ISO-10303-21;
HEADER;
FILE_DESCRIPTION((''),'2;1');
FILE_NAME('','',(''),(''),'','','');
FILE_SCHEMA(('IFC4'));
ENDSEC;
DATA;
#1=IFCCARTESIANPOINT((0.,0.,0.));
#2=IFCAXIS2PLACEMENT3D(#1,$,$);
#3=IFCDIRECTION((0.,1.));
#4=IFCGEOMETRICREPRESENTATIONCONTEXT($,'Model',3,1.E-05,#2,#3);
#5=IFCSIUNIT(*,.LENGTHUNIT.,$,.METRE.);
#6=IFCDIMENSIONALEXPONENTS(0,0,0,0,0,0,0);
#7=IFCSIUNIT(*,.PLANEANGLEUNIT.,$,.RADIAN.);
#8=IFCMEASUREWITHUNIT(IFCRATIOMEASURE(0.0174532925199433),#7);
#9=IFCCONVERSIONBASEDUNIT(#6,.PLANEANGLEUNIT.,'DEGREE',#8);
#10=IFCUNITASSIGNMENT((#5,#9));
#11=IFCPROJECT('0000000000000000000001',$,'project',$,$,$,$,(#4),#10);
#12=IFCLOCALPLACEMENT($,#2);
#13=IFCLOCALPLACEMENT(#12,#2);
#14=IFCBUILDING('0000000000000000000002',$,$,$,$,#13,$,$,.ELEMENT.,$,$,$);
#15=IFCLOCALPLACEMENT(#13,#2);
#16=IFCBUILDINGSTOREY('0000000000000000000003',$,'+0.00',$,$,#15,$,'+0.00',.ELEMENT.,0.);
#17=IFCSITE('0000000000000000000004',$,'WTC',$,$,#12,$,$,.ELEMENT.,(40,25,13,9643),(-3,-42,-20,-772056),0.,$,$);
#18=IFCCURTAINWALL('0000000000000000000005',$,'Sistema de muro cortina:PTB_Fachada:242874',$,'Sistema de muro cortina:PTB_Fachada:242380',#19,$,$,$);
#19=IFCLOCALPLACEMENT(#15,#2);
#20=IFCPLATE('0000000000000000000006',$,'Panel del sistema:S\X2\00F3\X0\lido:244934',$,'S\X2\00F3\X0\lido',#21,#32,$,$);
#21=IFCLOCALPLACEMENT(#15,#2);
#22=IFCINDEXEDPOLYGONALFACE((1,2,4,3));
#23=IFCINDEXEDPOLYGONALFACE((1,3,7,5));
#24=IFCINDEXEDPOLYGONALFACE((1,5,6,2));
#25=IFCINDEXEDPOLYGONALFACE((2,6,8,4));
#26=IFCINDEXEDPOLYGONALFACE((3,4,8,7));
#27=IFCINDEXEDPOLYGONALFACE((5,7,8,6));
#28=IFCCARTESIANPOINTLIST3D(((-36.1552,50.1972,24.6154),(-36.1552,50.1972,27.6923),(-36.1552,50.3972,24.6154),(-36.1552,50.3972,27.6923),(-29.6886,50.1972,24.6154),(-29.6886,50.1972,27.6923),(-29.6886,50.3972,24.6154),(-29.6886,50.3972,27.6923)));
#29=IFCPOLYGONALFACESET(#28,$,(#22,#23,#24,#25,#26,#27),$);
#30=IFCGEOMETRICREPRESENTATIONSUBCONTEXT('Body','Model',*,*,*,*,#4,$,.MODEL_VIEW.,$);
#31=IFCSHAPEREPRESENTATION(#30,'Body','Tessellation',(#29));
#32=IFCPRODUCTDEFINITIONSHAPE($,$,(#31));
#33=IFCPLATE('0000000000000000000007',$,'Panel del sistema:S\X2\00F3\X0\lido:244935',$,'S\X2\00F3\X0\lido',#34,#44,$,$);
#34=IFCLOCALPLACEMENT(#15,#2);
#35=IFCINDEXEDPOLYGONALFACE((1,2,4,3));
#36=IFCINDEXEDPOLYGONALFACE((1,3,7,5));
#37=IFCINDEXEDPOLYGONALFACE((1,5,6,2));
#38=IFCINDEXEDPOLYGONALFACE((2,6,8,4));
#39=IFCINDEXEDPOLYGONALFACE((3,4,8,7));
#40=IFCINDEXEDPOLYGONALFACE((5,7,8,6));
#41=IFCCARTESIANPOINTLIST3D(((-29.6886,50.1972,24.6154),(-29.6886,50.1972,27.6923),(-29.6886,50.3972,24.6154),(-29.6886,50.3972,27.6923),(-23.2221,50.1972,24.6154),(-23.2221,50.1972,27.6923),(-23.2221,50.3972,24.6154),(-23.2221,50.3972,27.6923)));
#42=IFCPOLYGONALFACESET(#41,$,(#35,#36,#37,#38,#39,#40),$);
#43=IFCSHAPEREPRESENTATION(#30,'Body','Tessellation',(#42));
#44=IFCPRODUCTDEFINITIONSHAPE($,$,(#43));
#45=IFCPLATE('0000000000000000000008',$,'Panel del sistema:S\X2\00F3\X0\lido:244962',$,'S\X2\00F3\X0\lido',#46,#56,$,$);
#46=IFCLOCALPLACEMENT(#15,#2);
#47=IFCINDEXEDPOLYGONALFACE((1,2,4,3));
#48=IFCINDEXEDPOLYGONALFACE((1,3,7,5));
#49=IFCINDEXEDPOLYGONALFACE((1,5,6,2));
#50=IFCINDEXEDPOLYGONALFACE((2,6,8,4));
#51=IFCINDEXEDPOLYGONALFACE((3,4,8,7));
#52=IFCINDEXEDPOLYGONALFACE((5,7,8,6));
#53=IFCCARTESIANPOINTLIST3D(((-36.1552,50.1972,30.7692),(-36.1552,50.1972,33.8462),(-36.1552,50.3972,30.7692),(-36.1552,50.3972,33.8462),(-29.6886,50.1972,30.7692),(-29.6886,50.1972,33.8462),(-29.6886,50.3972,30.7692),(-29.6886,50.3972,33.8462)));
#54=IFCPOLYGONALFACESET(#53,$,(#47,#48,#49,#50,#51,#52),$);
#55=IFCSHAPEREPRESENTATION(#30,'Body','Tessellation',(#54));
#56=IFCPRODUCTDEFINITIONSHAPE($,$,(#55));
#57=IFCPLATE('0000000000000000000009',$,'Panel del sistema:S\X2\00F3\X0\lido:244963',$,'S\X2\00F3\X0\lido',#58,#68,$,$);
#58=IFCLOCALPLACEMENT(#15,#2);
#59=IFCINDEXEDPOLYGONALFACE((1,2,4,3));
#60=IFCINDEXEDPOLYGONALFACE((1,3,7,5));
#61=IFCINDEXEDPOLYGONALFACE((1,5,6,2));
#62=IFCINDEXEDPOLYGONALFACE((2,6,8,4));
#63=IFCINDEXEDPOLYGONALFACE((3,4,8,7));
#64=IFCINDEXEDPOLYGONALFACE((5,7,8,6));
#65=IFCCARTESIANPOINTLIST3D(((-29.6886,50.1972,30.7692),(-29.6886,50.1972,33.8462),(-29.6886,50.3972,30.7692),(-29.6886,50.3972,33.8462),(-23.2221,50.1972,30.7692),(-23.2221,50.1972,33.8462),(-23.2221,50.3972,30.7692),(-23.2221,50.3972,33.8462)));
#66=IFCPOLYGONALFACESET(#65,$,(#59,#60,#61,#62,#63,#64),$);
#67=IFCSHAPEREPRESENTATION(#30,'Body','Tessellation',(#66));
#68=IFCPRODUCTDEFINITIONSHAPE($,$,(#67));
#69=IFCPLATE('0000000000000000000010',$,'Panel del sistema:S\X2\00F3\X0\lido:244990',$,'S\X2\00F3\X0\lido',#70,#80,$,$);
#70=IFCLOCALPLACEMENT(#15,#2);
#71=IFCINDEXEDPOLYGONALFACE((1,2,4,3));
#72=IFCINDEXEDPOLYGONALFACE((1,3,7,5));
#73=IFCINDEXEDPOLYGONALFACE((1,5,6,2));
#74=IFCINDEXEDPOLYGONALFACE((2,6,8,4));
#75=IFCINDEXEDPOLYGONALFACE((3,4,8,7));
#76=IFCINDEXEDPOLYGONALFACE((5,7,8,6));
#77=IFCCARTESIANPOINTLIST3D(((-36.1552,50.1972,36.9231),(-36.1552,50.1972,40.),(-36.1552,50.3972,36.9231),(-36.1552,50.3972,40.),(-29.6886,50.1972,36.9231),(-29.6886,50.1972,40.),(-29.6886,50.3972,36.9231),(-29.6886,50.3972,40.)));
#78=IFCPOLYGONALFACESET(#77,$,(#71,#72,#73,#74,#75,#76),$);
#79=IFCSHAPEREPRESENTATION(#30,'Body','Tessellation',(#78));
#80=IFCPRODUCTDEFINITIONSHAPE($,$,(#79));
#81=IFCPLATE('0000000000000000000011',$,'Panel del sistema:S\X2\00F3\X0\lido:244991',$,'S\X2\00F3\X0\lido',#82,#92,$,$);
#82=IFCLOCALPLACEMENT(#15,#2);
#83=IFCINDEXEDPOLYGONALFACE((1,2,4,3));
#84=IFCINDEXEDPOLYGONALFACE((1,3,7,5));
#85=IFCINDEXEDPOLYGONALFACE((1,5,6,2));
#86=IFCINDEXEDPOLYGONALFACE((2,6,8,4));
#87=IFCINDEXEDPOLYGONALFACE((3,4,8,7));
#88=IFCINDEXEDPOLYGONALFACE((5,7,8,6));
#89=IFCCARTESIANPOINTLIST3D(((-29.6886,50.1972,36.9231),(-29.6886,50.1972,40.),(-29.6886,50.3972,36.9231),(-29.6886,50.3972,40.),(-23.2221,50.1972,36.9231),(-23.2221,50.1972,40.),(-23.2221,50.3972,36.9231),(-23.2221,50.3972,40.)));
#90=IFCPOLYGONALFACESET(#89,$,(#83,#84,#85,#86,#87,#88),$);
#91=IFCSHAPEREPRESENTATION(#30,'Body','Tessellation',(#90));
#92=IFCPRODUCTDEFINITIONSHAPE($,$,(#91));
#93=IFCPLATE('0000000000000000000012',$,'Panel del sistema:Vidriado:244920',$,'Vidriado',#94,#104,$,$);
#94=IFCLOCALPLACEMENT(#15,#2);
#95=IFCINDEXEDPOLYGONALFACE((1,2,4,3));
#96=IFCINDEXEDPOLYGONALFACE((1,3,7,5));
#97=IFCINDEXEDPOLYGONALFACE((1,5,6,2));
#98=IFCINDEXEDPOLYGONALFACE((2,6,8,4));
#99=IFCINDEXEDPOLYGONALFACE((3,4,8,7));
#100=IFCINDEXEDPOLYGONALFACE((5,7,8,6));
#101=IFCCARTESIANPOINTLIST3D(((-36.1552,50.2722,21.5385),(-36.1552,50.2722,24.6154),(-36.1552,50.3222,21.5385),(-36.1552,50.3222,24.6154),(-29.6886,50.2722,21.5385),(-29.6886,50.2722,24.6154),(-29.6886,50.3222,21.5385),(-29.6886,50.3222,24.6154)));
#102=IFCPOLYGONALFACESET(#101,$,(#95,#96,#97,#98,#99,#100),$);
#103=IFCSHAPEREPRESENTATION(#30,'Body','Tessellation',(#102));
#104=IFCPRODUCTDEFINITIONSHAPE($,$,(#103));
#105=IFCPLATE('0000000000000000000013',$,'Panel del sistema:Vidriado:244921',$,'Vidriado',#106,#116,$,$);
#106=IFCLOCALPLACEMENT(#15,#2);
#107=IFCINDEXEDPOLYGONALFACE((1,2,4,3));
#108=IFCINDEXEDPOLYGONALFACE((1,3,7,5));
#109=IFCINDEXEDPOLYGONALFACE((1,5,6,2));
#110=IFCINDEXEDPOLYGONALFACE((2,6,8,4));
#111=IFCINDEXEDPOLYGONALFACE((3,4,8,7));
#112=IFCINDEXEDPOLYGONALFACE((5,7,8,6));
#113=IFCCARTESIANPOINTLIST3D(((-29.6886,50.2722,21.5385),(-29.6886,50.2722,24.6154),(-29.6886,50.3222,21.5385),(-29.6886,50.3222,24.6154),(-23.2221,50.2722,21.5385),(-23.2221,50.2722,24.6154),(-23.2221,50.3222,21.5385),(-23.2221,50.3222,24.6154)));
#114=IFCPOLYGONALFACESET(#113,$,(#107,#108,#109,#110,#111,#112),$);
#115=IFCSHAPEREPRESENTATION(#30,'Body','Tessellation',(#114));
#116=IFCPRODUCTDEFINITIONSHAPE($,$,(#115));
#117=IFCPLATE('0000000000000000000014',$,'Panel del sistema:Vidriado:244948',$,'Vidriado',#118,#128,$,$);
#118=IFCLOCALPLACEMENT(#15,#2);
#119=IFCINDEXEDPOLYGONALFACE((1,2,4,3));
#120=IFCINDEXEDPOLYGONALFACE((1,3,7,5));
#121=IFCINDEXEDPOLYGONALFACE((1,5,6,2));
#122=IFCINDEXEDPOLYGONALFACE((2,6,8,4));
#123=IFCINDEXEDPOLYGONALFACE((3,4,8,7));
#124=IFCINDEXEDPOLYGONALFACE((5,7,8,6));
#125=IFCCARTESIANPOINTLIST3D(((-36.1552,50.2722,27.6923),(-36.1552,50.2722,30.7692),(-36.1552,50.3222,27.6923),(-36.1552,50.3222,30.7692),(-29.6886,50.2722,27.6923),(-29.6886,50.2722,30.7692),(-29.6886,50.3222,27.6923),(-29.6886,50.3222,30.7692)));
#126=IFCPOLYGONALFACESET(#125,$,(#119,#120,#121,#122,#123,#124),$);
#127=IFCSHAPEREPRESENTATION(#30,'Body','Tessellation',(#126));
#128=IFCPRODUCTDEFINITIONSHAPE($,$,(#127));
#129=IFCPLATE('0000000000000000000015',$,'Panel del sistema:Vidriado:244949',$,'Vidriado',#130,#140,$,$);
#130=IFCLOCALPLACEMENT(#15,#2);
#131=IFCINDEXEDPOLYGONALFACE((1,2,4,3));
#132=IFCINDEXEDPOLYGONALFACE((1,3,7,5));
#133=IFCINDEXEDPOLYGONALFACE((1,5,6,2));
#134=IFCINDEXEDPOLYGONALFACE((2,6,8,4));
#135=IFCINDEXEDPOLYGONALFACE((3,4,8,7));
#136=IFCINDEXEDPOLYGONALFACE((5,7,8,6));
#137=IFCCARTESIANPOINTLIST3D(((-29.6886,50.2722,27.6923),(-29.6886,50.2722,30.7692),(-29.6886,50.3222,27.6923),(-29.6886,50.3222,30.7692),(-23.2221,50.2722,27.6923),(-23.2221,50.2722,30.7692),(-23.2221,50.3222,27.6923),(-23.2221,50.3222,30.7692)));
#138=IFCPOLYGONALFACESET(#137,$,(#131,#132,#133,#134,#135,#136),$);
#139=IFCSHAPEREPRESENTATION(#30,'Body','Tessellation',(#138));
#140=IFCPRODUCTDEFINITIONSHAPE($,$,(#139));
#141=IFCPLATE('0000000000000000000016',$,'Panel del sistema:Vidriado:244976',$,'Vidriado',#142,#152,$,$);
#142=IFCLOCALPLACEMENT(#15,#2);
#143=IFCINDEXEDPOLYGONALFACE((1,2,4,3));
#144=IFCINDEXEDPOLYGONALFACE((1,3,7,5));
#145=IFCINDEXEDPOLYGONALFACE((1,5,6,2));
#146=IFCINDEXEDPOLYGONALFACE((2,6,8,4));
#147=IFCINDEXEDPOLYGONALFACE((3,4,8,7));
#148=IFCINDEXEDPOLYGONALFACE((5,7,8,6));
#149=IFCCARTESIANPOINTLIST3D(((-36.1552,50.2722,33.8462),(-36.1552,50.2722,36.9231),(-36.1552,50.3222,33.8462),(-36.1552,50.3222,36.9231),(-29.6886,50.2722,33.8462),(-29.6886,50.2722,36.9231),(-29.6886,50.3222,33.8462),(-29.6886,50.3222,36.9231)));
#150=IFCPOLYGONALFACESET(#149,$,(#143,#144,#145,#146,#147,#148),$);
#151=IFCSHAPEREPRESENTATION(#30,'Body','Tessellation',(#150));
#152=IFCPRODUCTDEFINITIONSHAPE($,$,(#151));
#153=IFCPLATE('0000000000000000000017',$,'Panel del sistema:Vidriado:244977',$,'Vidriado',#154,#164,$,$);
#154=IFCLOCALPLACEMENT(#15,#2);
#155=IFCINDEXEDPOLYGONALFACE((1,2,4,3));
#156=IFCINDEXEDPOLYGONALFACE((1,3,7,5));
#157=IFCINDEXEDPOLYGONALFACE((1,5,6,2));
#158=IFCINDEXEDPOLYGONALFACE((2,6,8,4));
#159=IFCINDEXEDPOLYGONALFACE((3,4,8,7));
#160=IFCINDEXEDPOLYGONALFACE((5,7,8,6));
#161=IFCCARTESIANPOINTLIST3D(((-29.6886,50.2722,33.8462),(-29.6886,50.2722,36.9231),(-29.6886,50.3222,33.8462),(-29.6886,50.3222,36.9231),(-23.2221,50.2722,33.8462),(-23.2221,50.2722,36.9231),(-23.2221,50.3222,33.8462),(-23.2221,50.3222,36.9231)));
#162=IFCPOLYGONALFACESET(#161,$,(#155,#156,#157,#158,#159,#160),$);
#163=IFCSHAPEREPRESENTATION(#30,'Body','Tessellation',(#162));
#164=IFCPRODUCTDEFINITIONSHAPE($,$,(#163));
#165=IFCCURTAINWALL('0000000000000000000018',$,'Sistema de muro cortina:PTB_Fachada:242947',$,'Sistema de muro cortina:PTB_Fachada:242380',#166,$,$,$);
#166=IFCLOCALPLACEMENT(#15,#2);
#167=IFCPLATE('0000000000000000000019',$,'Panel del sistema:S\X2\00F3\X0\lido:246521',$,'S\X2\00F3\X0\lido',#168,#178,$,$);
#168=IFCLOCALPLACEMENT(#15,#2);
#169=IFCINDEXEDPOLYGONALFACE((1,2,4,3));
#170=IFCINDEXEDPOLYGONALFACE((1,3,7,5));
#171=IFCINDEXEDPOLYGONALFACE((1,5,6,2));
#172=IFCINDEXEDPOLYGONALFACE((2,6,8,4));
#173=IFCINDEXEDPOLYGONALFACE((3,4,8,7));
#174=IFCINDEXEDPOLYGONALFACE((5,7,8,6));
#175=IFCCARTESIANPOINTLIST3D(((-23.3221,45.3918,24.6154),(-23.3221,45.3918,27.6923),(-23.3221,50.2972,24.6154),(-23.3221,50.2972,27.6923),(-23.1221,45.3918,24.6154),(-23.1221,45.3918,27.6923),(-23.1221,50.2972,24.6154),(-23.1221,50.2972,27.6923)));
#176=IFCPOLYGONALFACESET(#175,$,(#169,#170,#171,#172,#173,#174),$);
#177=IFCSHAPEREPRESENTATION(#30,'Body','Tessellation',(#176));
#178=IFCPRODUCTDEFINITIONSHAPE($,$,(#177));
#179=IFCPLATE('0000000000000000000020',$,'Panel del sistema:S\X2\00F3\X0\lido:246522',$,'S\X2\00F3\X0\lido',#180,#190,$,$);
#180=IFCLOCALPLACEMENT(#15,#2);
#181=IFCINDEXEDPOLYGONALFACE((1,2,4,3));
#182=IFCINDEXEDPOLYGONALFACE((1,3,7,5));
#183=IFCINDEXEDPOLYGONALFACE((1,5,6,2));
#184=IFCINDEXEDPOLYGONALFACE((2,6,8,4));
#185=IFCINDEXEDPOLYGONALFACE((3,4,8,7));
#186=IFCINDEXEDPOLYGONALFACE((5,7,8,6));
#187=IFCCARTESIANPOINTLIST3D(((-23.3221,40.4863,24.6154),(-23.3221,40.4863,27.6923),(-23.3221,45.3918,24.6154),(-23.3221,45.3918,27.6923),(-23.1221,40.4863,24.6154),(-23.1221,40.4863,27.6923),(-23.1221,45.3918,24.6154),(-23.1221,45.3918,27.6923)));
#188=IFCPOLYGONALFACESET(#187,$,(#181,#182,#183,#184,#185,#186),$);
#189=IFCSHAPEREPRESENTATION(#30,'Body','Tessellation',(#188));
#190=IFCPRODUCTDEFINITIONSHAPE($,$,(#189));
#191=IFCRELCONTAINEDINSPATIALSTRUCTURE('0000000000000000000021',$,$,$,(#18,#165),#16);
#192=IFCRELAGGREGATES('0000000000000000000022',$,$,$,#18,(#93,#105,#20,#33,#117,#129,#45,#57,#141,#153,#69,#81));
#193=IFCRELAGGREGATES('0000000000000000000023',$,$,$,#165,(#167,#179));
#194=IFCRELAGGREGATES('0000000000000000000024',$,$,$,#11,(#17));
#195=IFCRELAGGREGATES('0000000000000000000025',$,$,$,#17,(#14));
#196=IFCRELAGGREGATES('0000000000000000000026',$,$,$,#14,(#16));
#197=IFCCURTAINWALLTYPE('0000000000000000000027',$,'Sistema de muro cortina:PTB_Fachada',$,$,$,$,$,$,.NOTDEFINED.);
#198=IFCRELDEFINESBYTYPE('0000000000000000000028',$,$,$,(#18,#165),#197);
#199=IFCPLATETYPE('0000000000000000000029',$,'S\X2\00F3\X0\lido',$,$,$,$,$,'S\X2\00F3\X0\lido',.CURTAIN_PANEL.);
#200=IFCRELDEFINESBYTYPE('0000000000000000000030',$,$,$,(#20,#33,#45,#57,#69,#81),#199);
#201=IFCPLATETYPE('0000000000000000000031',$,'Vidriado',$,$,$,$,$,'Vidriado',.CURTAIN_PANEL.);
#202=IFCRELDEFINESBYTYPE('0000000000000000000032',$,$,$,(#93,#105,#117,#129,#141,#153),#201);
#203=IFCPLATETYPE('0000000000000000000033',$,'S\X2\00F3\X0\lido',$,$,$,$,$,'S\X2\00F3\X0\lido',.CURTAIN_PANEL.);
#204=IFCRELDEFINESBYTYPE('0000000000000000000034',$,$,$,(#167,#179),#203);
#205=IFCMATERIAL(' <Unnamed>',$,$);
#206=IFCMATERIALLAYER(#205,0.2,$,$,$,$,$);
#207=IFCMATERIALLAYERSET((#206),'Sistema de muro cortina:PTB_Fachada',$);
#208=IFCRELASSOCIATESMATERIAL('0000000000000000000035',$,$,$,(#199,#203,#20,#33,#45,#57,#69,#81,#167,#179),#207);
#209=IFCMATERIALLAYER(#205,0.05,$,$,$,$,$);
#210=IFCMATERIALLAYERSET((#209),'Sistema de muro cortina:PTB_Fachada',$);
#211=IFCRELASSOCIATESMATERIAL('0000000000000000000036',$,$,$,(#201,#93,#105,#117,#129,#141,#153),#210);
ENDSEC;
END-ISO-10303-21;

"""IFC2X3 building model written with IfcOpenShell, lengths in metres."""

from ifc_helpers import new_model, entity, si_unit, converted_unit, direction, frame, origin, origin_2d_with_axis, place, context, subcontext, project, spatial, rectangle, extrude, source, transform, mapped, material, layer, layer_set, layer_usage, type_object, type_shapes, element, aggregate, save


model = new_model("IFC2X3")

# Units and contexts
model_context = context("Model", 3, precision=1e-05, world=origin(), true_north=direction((0.0, 1.0)))
body_context = subcontext(model_context, "Body", "Model", "MODEL_VIEW")
ifc_project = project(units=[si_unit("LENGTHUNIT", "METRE"), converted_unit("PLANEANGLEUNIT", "DEGREE", entity("IfcRatioMeasure", 0.0174532925199433), si_unit("PLANEANGLEUNIT", "RADIAN"), dimensions=[0, 0, 0, 0, 0, 0, 0])], contexts=[model_context])

# Site, building, storey
site_placement = place(None, origin())
site = spatial("IfcSite", under=ifc_project, at=site_placement, Name="WTC", CompositionType="ELEMENT", RefLatitude=(40, 25, 13, 9643), RefLongitude=(-3, -42, -20, -772056), RefElevation=0.0)
building_placement = place(site_placement, origin())
building = spatial("IfcBuilding", under=site, at=building_placement, CompositionType="ELEMENT")
storey_placement = place(building_placement, origin())
storey = spatial("IfcBuildingStorey", under=building, at=storey_placement, Name="+0.00", LongName="+0.00", CompositionType="ELEMENT", Elevation=0.0)

# Shared definitions
curtain_wall_type = type_object("IfcCurtainWallType", Name="Sistema de muro cortina:PTB_Fachada", PredefinedType="NOTDEFINED")
ifc_material = material(Name=" <Unnamed>")
ifc_layer_1 = layer(ifc_material, 0.2)
ifc_layer_set_1 = layer_set([ifc_layer_1], Name="Sistema de muro cortina:PTB_Fachada")

# Curtain walls, plates
curtain_wall_1_placement = place(storey_placement, origin())
curtain_wall_1 = element("IfcCurtainWall", 1, at=curtain_wall_1_placement, inside=storey, type_object=curtain_wall_type, Name="Sistema de muro cortina:PTB_Fachada:242874", ObjectType="Sistema de muro cortina:PTB_Fachada:242380")
ifc_layer_usage_1 = layer_usage(ifc_layer_set_1, "AXIS3", "POSITIVE", 0.0)
plate_type_1 = type_object("IfcPlateType", Name="Sólido", ElementType="Sólido", PredefinedType="CURTAIN_PANEL", material=ifc_layer_set_1)
shared_shape_1 = source(origin(), body_context, "Body", "SweptSolid", [
    extrude(rectangle(XDim=0.2, YDim=6.4666, at=origin_2d_with_axis()), frame((0.0, 0.0, 0.0), z_axis=(0.0, 0.0, 1.0), x_axis=(0.0, 1.0, 0.0)), (0.0, 0.0, 1.0), 3.0769),
])
type_shapes(plate_type_1, [shared_shape_1])
plate_1_placement = place(curtain_wall_1_placement, frame((-32.9219, 50.2972, 24.6154)))
plate_1 = element("IfcPlate", 2, at=plate_1_placement, type_object=plate_type_1, material=ifc_layer_usage_1, Name="Panel del sistema:Sólido:244934", ObjectType="Sólido", context=body_context, shape_type="MappedRepresentation", body=[
    mapped(shared_shape_1, transform((0.0, 0.0, 0.0), scale=1.0)),
])
ifc_layer_usage_2 = layer_usage(ifc_layer_set_1, "AXIS3", "POSITIVE", 0.0)
plate_2_placement = place(curtain_wall_1_placement, frame((-26.4554, 50.2972, 24.6154)))
plate_2 = element("IfcPlate", 3, at=plate_2_placement, type_object=plate_type_1, material=ifc_layer_usage_2, Name="Panel del sistema:Sólido:244935", ObjectType="Sólido", context=body_context, shape_type="MappedRepresentation", body=[
    mapped(shared_shape_1, transform((0.0, 0.0, 0.0), scale=1.0)),
])
ifc_layer_usage_3 = layer_usage(ifc_layer_set_1, "AXIS3", "POSITIVE", 0.0)
plate_3_placement = place(curtain_wall_1_placement, frame((-32.9219, 50.2972, 30.7692)))
plate_3 = element("IfcPlate", 4, at=plate_3_placement, type_object=plate_type_1, material=ifc_layer_usage_3, Name="Panel del sistema:Sólido:244962", ObjectType="Sólido", context=body_context, shape_type="MappedRepresentation", body=[
    mapped(shared_shape_1, transform((0.0, 0.0, 0.0), scale=1.0)),
])
ifc_layer_usage_4 = layer_usage(ifc_layer_set_1, "AXIS3", "POSITIVE", 0.0)
plate_4_placement = place(curtain_wall_1_placement, frame((-26.4554, 50.2972, 30.7692)))
plate_4 = element("IfcPlate", 5, at=plate_4_placement, type_object=plate_type_1, material=ifc_layer_usage_4, Name="Panel del sistema:Sólido:244963", ObjectType="Sólido", context=body_context, shape_type="MappedRepresentation", body=[
    mapped(shared_shape_1, transform((0.0, 0.0, 0.0), scale=1.0)),
])
ifc_layer_usage_5 = layer_usage(ifc_layer_set_1, "AXIS3", "POSITIVE", 0.0)
plate_5_placement = place(curtain_wall_1_placement, frame((-32.9219, 50.2972, 36.9231)))
plate_5 = element("IfcPlate", 6, at=plate_5_placement, type_object=plate_type_1, material=ifc_layer_usage_5, Name="Panel del sistema:Sólido:244990", ObjectType="Sólido", context=body_context, shape_type="MappedRepresentation", body=[
    mapped(shared_shape_1, transform((0.0, 0.0, 0.0), scale=1.0)),
])
ifc_layer_usage_6 = layer_usage(ifc_layer_set_1, "AXIS3", "POSITIVE", 0.0)
plate_6_placement = place(curtain_wall_1_placement, frame((-26.4554, 50.2972, 36.9231)))
plate_6 = element("IfcPlate", 7, at=plate_6_placement, type_object=plate_type_1, material=ifc_layer_usage_6, Name="Panel del sistema:Sólido:244991", ObjectType="Sólido", context=body_context, shape_type="MappedRepresentation", body=[
    mapped(shared_shape_1, transform((0.0, 0.0, 0.0), scale=1.0)),
])
ifc_layer_2 = layer(ifc_material, 0.05)
ifc_layer_set_2 = layer_set([ifc_layer_2], Name="Sistema de muro cortina:PTB_Fachada")
ifc_layer_usage_7 = layer_usage(ifc_layer_set_2, "AXIS3", "POSITIVE", 0.0)
plate_type_2 = type_object("IfcPlateType", Name="Vidriado", ElementType="Vidriado", PredefinedType="CURTAIN_PANEL", material=ifc_layer_set_2)
shared_shape_2 = source(origin(), body_context, "Body", "SweptSolid", [
    extrude(rectangle(XDim=0.05, YDim=6.4666, at=origin_2d_with_axis()), frame((0.0, 0.0, 0.0), z_axis=(0.0, 0.0, 1.0), x_axis=(0.0, 1.0, 0.0)), (0.0, 0.0, 1.0), 3.0769),
])
type_shapes(plate_type_2, [shared_shape_2])
plate_7_placement = place(curtain_wall_1_placement, frame((-32.9219, 50.2972, 21.5385)))
plate_7 = element("IfcPlate", 8, at=plate_7_placement, type_object=plate_type_2, material=ifc_layer_usage_7, Name="Panel del sistema:Vidriado:244920", ObjectType="Vidriado", context=body_context, shape_type="MappedRepresentation", body=[
    mapped(shared_shape_2, transform((0.0, 0.0, 0.0), scale=1.0)),
])
ifc_layer_usage_8 = layer_usage(ifc_layer_set_2, "AXIS3", "POSITIVE", 0.0)
plate_8_placement = place(curtain_wall_1_placement, frame((-26.4554, 50.2972, 21.5385)))
plate_8 = element("IfcPlate", 9, at=plate_8_placement, type_object=plate_type_2, material=ifc_layer_usage_8, Name="Panel del sistema:Vidriado:244921", ObjectType="Vidriado", context=body_context, shape_type="MappedRepresentation", body=[
    mapped(shared_shape_2, transform((0.0, 0.0, 0.0), scale=1.0)),
])
ifc_layer_usage_9 = layer_usage(ifc_layer_set_2, "AXIS3", "POSITIVE", 0.0)
plate_9_placement = place(curtain_wall_1_placement, frame((-32.9219, 50.2972, 27.6923)))
plate_9 = element("IfcPlate", 10, at=plate_9_placement, type_object=plate_type_2, material=ifc_layer_usage_9, Name="Panel del sistema:Vidriado:244948", ObjectType="Vidriado", context=body_context, shape_type="MappedRepresentation", body=[
    mapped(shared_shape_2, transform((0.0, 0.0, 0.0), scale=1.0)),
])
ifc_layer_usage_10 = layer_usage(ifc_layer_set_2, "AXIS3", "POSITIVE", 0.0)
plate_10_placement = place(curtain_wall_1_placement, frame((-26.4554, 50.2972, 27.6923)))
plate_10 = element("IfcPlate", 11, at=plate_10_placement, type_object=plate_type_2, material=ifc_layer_usage_10, Name="Panel del sistema:Vidriado:244949", ObjectType="Vidriado", context=body_context, shape_type="MappedRepresentation", body=[
    mapped(shared_shape_2, transform((0.0, 0.0, 0.0), scale=1.0)),
])
ifc_layer_usage_11 = layer_usage(ifc_layer_set_2, "AXIS3", "POSITIVE", 0.0)
plate_11_placement = place(curtain_wall_1_placement, frame((-32.9219, 50.2972, 33.8462)))
plate_11 = element("IfcPlate", 12, at=plate_11_placement, type_object=plate_type_2, material=ifc_layer_usage_11, Name="Panel del sistema:Vidriado:244976", ObjectType="Vidriado", context=body_context, shape_type="MappedRepresentation", body=[
    mapped(shared_shape_2, transform((0.0, 0.0, 0.0), scale=1.0)),
])
ifc_layer_usage_12 = layer_usage(ifc_layer_set_2, "AXIS3", "POSITIVE", 0.0)
plate_12_placement = place(curtain_wall_1_placement, frame((-26.4554, 50.2972, 33.8462)))
plate_12 = element("IfcPlate", 13, at=plate_12_placement, type_object=plate_type_2, material=ifc_layer_usage_12, Name="Panel del sistema:Vidriado:244977", ObjectType="Vidriado", context=body_context, shape_type="MappedRepresentation", body=[
    mapped(shared_shape_2, transform((0.0, 0.0, 0.0), scale=1.0)),
])
aggregate(curtain_wall_1, [plate_7, plate_8, plate_1, plate_2, plate_9, plate_10, plate_3, plate_4, plate_11, plate_12, plate_5, plate_6])
curtain_wall_2_placement = place(storey_placement, origin())
curtain_wall_2 = element("IfcCurtainWall", 14, at=curtain_wall_2_placement, inside=storey, type_object=curtain_wall_type, Name="Sistema de muro cortina:PTB_Fachada:242947", ObjectType="Sistema de muro cortina:PTB_Fachada:242380")
ifc_layer_usage_13 = layer_usage(ifc_layer_set_1, "AXIS3", "POSITIVE", 0.0)
plate_type_3 = type_object("IfcPlateType", Name="Sólido", ElementType="Sólido", PredefinedType="CURTAIN_PANEL", material=ifc_layer_set_1)
shared_shape_3 = source(origin(), body_context, "Body", "SweptSolid", [
    extrude(rectangle(XDim=0.2, YDim=4.9055, at=origin_2d_with_axis()), frame((0.0, 0.0, 0.0), z_axis=(0.0, 0.0, 1.0), x_axis=(0.0, 1.0, 0.0)), (0.0, 0.0, 1.0), 3.0769),
])
type_shapes(plate_type_3, [shared_shape_3])
plate_13_placement = place(curtain_wall_2_placement, frame((-23.2221, 47.8445, 24.6154), z_axis=(0.0, 0.0, 1.0), x_axis=(0.0, -1.0, 0.0)))
plate_13 = element("IfcPlate", 15, at=plate_13_placement, type_object=plate_type_3, material=ifc_layer_usage_13, Name="Panel del sistema:Sólido:246521", ObjectType="Sólido", context=body_context, shape_type="MappedRepresentation", body=[
    mapped(shared_shape_3, transform((0.0, 0.0, 0.0), scale=1.0)),
])
ifc_layer_usage_14 = layer_usage(ifc_layer_set_1, "AXIS3", "POSITIVE", 0.0)
plate_14_placement = place(curtain_wall_2_placement, frame((-23.2221, 42.939, 24.6154), z_axis=(0.0, 0.0, 1.0), x_axis=(0.0, -1.0, 0.0)))
plate_14 = element("IfcPlate", 16, at=plate_14_placement, type_object=plate_type_3, material=ifc_layer_usage_14, Name="Panel del sistema:Sólido:246522", ObjectType="Sólido", context=body_context, shape_type="MappedRepresentation", body=[
    mapped(shared_shape_3, transform((0.0, 0.0, 0.0), scale=1.0)),
])
aggregate(curtain_wall_2, [plate_13, plate_14])

save(model, "model.ifc")
